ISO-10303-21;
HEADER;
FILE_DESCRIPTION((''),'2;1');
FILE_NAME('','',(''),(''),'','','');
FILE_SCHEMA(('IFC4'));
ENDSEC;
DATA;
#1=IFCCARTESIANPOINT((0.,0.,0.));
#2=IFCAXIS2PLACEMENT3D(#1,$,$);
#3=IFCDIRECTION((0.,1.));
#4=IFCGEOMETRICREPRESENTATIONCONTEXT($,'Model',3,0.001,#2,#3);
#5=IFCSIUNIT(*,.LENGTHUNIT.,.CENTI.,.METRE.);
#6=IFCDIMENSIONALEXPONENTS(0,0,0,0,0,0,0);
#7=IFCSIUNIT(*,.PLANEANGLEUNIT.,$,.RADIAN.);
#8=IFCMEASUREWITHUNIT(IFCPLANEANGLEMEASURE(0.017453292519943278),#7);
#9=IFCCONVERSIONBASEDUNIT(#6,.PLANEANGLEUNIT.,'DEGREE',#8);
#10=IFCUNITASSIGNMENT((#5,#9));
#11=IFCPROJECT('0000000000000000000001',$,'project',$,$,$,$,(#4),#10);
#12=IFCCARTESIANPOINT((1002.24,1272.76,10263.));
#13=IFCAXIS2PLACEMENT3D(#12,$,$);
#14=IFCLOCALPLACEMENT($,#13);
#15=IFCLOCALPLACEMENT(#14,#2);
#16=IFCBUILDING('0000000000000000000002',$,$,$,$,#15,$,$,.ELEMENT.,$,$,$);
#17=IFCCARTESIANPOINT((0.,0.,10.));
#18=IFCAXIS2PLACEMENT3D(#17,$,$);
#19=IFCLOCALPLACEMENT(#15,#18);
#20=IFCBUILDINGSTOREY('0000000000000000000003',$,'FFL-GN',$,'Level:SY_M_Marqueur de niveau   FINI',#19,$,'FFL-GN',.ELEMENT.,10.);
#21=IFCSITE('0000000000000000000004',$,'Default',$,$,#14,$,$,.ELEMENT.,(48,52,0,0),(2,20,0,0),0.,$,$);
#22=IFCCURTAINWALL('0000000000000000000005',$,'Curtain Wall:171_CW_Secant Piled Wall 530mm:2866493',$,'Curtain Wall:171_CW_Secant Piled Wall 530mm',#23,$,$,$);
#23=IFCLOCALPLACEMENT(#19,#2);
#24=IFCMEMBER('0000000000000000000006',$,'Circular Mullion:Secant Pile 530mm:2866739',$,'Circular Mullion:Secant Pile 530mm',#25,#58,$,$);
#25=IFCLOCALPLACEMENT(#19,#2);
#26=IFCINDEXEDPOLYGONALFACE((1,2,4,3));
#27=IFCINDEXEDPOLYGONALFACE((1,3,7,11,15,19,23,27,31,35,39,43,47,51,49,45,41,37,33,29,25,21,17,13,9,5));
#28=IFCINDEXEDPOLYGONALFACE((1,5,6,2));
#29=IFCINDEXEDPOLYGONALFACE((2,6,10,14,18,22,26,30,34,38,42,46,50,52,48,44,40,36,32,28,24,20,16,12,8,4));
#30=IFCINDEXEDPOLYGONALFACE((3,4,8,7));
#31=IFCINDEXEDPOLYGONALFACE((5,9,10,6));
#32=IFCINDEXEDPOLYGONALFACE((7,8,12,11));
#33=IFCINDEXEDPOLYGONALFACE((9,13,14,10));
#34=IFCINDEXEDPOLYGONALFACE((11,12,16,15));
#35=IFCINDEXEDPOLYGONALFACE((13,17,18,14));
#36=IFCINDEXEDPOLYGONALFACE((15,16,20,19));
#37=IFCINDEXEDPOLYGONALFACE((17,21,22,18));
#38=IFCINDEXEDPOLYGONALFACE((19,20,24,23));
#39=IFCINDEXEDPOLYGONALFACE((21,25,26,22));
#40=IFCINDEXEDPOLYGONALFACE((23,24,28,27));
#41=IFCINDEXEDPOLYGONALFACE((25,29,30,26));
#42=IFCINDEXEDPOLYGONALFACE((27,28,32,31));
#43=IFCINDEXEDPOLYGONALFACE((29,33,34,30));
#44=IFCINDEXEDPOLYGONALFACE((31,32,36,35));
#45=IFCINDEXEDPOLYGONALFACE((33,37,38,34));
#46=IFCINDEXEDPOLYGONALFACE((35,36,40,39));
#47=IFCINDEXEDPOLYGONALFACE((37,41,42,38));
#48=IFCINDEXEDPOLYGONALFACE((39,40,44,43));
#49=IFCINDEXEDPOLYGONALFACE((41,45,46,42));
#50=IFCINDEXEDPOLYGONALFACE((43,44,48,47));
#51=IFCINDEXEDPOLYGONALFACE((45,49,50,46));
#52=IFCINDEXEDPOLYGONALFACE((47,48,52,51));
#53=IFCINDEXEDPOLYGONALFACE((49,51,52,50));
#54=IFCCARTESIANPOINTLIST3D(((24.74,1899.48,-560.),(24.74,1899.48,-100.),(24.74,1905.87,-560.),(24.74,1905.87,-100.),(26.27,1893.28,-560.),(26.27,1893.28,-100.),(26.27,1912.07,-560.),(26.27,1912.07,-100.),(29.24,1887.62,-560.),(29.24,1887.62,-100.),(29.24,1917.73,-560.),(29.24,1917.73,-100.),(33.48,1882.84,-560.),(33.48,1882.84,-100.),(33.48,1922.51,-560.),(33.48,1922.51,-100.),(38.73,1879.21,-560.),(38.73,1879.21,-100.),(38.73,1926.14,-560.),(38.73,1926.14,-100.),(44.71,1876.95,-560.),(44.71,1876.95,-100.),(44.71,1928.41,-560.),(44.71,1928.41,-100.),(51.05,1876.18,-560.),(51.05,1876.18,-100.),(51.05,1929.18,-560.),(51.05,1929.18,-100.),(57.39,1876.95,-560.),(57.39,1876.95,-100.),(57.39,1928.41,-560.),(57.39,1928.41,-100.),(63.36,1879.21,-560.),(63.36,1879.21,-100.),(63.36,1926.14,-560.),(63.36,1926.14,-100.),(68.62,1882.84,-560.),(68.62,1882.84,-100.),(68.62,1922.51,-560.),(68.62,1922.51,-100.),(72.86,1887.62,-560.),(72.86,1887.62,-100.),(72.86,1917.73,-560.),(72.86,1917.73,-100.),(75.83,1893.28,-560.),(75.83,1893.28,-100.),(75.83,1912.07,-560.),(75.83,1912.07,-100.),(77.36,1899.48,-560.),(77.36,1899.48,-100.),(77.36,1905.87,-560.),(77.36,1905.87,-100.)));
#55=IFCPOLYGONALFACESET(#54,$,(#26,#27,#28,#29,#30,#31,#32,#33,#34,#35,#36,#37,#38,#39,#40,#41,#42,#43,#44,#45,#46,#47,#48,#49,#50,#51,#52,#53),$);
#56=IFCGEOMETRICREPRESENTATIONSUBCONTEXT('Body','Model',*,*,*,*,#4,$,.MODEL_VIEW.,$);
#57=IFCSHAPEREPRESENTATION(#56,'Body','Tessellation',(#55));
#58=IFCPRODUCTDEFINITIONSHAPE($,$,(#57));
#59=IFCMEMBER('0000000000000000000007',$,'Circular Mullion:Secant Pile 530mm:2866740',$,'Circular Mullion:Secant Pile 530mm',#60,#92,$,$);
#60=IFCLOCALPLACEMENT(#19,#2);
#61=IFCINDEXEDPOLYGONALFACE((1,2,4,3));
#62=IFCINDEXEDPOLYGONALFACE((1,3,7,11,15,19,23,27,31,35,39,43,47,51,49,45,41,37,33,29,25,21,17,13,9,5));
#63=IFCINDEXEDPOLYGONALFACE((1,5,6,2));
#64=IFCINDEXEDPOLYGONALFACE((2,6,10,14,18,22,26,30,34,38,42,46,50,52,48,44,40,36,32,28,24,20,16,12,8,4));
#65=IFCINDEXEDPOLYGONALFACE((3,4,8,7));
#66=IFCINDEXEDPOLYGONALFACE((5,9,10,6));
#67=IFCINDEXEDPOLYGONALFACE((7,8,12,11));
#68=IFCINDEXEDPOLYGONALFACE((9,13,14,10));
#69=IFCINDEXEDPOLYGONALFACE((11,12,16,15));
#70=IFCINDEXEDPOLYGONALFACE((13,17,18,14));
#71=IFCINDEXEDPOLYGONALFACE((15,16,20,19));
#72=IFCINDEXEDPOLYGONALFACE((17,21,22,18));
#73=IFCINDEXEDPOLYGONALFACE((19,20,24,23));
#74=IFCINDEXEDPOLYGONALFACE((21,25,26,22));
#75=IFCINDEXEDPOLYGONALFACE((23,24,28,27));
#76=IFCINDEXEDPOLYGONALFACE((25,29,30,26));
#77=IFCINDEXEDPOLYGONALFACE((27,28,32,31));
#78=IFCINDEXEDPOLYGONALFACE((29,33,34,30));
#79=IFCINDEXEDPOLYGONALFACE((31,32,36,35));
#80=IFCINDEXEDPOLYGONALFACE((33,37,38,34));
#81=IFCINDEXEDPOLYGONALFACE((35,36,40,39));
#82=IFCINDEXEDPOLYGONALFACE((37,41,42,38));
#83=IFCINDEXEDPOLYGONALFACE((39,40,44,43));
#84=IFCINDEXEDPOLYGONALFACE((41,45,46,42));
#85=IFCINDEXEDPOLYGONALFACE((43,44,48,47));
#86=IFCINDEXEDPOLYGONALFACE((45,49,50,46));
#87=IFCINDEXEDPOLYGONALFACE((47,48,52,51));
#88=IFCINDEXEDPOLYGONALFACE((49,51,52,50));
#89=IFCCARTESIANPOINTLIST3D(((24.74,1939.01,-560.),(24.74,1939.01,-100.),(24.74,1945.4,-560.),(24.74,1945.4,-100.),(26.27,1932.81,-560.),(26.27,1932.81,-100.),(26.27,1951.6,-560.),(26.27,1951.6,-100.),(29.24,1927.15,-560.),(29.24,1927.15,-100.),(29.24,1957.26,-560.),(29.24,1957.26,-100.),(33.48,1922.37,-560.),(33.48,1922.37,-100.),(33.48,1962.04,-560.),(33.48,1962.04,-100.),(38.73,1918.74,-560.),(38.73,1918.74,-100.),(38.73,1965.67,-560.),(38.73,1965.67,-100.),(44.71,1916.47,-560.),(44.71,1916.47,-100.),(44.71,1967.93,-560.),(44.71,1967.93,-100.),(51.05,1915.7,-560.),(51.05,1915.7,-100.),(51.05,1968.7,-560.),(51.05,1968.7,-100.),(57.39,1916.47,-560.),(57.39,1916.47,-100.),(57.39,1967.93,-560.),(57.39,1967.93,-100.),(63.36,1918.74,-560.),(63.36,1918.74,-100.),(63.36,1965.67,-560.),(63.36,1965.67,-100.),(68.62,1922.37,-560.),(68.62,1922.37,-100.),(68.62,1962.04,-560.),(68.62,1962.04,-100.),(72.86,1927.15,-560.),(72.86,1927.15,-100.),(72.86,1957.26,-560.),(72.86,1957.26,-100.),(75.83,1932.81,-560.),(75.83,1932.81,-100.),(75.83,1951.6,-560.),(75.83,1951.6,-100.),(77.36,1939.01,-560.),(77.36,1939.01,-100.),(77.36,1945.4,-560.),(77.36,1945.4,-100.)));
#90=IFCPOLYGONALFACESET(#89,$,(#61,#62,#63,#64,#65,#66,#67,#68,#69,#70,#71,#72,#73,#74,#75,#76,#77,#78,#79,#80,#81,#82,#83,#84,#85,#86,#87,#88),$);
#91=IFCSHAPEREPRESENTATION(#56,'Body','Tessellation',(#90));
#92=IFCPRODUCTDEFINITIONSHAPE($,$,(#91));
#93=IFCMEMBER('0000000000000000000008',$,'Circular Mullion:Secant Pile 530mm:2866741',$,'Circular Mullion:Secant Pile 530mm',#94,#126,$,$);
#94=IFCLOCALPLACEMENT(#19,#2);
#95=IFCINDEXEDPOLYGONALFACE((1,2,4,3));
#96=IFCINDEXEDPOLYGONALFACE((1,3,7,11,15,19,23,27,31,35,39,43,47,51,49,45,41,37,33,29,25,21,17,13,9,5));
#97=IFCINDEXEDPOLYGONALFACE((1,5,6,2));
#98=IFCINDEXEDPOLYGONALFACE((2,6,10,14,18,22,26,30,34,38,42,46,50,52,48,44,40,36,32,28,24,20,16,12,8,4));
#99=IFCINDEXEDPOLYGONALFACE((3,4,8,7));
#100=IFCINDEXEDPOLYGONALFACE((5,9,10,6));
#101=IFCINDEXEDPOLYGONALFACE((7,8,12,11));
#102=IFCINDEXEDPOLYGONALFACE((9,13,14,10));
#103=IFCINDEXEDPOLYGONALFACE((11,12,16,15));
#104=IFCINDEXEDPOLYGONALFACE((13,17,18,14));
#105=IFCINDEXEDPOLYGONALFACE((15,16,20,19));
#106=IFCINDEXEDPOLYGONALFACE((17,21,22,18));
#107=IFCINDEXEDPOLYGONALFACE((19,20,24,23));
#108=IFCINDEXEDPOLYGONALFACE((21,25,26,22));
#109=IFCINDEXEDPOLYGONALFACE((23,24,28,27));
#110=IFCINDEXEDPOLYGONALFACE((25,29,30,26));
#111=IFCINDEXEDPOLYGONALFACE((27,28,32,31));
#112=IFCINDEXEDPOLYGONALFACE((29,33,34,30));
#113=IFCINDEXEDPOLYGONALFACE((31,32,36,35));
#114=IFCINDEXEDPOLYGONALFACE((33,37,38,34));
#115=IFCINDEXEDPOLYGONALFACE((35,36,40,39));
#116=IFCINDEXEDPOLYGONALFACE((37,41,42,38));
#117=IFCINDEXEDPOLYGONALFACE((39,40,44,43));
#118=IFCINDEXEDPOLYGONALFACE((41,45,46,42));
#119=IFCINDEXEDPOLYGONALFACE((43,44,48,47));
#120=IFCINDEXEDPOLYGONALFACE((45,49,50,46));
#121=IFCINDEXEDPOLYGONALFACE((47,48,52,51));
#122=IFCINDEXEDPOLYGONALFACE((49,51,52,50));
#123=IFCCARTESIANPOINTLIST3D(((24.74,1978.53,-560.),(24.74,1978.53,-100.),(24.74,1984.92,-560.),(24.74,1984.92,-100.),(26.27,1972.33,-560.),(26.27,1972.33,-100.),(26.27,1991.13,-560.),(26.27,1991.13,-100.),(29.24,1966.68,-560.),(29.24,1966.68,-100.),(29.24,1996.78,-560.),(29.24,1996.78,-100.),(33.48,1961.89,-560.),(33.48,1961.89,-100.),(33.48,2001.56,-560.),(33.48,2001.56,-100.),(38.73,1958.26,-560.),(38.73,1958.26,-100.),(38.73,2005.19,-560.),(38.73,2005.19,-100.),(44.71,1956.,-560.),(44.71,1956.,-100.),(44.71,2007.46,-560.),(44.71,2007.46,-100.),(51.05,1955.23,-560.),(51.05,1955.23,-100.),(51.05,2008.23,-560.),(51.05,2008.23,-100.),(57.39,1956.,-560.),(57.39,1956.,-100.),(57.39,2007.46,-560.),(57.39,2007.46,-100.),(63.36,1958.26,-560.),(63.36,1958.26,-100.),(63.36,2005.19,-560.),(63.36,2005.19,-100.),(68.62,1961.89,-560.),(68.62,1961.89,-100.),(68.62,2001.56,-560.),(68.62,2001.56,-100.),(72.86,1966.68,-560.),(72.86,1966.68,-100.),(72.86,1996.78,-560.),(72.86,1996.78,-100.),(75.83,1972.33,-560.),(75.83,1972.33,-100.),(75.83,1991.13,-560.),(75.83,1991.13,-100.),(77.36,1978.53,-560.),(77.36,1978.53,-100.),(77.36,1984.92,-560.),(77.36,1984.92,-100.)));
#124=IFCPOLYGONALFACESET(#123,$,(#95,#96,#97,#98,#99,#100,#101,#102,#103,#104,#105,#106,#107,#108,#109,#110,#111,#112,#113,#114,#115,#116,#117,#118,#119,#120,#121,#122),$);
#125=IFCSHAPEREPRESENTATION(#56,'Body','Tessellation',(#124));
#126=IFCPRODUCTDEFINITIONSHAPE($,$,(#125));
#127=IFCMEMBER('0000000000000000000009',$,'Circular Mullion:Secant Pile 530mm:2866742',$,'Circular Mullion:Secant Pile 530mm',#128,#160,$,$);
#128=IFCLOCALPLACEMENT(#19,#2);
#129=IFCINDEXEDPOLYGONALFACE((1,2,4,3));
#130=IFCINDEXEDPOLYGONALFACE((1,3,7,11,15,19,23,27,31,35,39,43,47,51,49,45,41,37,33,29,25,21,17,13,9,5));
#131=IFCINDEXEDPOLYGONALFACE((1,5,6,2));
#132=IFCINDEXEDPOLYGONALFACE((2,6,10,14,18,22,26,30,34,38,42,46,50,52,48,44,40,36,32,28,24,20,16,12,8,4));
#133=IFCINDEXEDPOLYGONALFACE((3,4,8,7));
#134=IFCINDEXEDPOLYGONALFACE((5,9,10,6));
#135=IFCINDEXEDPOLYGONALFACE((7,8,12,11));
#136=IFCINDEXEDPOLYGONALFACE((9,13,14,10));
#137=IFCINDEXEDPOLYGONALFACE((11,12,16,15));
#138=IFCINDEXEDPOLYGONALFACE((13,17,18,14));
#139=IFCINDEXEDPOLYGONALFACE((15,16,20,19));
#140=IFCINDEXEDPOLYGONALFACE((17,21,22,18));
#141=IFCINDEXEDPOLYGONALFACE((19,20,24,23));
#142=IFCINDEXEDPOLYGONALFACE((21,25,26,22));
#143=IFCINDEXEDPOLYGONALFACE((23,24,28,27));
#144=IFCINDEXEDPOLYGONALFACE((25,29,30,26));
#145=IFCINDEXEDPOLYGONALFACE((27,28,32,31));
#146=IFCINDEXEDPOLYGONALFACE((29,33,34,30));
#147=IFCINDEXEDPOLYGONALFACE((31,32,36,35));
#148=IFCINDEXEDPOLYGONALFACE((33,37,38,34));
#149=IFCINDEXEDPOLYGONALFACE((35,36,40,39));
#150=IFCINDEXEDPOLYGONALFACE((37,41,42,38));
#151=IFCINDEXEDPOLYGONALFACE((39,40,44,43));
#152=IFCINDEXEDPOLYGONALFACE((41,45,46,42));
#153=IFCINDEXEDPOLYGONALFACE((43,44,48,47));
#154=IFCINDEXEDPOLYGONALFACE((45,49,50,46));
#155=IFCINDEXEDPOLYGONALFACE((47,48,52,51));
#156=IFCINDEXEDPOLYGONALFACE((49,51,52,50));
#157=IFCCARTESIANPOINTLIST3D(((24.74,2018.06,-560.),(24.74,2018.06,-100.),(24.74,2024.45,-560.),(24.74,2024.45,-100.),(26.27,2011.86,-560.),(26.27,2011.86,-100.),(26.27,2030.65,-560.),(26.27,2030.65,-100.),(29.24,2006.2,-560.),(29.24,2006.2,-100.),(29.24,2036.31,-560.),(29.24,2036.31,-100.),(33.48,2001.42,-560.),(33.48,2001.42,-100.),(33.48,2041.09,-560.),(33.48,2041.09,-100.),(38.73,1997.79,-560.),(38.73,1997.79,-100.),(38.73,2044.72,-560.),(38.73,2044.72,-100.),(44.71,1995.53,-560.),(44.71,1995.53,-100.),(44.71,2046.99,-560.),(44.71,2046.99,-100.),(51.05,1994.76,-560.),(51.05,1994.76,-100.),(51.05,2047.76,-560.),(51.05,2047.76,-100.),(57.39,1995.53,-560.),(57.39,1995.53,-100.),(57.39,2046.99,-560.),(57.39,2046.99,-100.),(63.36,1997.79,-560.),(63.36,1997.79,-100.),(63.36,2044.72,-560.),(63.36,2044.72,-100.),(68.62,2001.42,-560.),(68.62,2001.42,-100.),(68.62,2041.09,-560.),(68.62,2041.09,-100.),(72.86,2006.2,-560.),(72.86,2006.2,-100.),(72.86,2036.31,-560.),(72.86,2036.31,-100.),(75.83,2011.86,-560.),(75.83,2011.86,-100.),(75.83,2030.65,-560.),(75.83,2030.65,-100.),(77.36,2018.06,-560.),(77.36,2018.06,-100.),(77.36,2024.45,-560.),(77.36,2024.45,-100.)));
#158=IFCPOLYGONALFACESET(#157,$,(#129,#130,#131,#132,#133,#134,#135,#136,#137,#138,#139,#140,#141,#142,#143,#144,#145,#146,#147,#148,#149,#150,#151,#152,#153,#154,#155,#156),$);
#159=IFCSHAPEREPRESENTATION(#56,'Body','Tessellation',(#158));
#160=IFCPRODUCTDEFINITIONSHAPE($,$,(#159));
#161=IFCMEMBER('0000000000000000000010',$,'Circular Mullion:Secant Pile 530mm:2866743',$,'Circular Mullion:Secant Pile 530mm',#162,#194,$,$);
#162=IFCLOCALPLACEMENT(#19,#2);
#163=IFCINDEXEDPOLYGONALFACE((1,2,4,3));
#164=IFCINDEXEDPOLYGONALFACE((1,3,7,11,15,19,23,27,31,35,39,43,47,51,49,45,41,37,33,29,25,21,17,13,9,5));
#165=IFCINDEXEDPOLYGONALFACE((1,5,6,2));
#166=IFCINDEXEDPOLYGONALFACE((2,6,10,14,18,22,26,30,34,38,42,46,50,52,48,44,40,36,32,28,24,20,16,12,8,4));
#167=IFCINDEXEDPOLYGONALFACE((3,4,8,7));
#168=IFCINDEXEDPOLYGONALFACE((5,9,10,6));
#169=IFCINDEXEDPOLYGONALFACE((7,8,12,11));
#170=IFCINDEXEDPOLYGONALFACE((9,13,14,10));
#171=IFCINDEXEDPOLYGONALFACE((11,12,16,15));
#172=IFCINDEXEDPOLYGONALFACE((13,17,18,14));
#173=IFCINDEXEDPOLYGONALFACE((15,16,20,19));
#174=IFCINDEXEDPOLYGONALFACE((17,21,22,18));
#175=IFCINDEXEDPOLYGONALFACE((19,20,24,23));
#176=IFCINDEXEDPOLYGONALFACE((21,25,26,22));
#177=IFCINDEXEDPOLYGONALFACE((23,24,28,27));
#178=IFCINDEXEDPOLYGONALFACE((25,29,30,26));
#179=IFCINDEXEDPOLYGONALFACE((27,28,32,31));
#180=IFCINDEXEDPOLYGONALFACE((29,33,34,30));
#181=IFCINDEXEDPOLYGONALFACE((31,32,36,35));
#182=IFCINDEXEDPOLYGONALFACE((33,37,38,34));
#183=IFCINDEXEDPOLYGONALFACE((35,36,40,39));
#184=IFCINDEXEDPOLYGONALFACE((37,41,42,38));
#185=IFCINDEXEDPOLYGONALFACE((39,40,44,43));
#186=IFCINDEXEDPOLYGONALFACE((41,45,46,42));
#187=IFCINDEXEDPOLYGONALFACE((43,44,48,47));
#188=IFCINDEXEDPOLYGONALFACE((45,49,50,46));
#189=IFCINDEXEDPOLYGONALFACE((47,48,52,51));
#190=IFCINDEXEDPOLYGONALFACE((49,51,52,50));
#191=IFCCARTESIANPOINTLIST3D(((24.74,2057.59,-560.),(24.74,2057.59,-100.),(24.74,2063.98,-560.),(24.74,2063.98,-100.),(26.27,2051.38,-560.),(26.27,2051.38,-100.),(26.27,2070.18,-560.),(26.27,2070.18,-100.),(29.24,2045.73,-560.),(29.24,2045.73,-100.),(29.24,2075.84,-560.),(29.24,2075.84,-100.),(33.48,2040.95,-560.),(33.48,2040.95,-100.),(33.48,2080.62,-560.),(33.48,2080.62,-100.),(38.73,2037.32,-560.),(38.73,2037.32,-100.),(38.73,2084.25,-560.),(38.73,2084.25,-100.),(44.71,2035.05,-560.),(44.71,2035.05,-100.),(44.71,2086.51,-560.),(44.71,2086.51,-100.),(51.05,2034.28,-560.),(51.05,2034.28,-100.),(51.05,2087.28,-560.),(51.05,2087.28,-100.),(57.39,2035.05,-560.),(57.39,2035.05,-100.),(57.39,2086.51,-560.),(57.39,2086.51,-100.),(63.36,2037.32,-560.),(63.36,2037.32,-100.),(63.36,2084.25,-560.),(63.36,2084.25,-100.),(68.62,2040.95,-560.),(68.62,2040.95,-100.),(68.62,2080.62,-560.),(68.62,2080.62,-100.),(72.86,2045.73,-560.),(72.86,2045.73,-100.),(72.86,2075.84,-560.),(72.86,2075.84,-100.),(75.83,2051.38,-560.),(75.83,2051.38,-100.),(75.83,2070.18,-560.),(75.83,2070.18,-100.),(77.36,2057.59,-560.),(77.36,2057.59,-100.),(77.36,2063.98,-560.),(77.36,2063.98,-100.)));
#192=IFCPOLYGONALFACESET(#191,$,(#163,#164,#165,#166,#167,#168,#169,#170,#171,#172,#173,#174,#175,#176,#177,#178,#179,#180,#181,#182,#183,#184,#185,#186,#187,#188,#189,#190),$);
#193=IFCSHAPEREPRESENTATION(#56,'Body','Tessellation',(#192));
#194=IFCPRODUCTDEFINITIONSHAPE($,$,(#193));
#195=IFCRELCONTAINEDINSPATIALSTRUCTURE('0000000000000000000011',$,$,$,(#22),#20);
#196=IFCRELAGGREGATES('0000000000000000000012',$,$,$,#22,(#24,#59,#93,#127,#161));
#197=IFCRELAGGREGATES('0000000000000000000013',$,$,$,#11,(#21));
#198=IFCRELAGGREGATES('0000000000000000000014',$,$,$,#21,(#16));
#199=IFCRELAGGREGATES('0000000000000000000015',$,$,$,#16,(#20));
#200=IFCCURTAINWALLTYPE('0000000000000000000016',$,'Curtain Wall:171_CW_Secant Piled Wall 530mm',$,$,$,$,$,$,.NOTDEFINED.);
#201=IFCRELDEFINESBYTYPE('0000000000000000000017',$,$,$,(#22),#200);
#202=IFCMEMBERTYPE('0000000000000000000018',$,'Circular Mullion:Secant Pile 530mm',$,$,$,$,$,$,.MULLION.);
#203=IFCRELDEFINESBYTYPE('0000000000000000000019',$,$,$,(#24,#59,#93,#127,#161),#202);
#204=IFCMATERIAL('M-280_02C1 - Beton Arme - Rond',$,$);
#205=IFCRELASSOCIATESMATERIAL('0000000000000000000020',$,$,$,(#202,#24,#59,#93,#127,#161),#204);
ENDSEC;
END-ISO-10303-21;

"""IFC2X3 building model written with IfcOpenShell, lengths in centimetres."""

from ifc_helpers import new_model, entity, si_unit, converted_unit, direction, frame, frame_2d, origin, place, context, subcontext, project, spatial, circle, extrude, source, transform, mapped, material, type_object, type_shapes, element, aggregate, save


model = new_model("IFC2X3")

# Units and contexts
model_context = context("Model", 3, precision=0.001, world=origin(), true_north=direction((0.0, 1.0)))
body_context = subcontext(model_context, "Body", "Model", "MODEL_VIEW")
ifc_project = project(units=[si_unit("LENGTHUNIT", "METRE", prefix="CENTI"), converted_unit("PLANEANGLEUNIT", "DEGREE", entity("IfcPlaneAngleMeasure", 0.017453292519943278), si_unit("PLANEANGLEUNIT", "RADIAN"), dimensions=[0, 0, 0, 0, 0, 0, 0])], contexts=[model_context])

# Site, building, storey
site_placement = place(None, frame((1002.24, 1272.76, 10263.0)))
site = spatial("IfcSite", under=ifc_project, at=site_placement, Name="Default", CompositionType="ELEMENT", RefLatitude=(48, 52, 0, 0), RefLongitude=(2, 20, 0, 0), RefElevation=0.0)
building_placement = place(site_placement, origin())
building = spatial("IfcBuilding", under=site, at=building_placement, CompositionType="ELEMENT")
storey_placement = place(building_placement, frame((0.0, 0.0, 10.0)))
storey = spatial("IfcBuildingStorey", under=building, at=storey_placement, Name="FFL-GN", ObjectType="Level:SY_M_Marqueur de niveau   FINI", LongName="FFL-GN", CompositionType="ELEMENT", Elevation=10.0)

# Curtain wall, members
curtain_wall_type = type_object("IfcCurtainWallType", Name="Curtain Wall:171_CW_Secant Piled Wall 530mm", PredefinedType="NOTDEFINED")
curtain_wall_placement = place(storey_placement, frame((0.0, 0.0, -10.0)))
curtain_wall = element("IfcCurtainWall", 1, at=curtain_wall_placement, inside=storey, type_object=curtain_wall_type, Name="Curtain Wall:171_CW_Secant Piled Wall 530mm:2866493", ObjectType="Curtain Wall:171_CW_Secant Piled Wall 530mm")
ifc_material_1 = material(Name="M-280_02C1 - Beton Arme - Rond")
member_type = type_object("IfcMemberType", Name="Circular Mullion:Secant Pile 530mm", PredefinedType="MULLION", material=ifc_material_1)
shared_shape = source(origin(), body_context, "Body", "SweptSolid", [
    extrude(circle(Radius=26.5, at=frame_2d((0.0, 0.0), x_axis=(1.0, 0.0))), frame((0.0, 0.0, -460.0)), (0.0, 0.0, 1.0), 460.0),
])
type_shapes(member_type, [shared_shape])
member_1_placement = place(curtain_wall_placement, frame((51.05, 1902.68, -550.0), z_axis=(0.0, 0.0, -1.0), x_axis=(0.0, 1.0, 0.0)))
member_1 = element("IfcMember", 2, at=member_1_placement, type_object=member_type, material=ifc_material_1, Name="Circular Mullion:Secant Pile 530mm:2866739", ObjectType="Circular Mullion:Secant Pile 530mm", context=body_context, shape_type="MappedRepresentation", body=[
    mapped(shared_shape, transform((0.0, 0.0, 0.0), scale=1.0)),
])
member_2_placement = place(curtain_wall_placement, frame((51.05, 1942.2, -550.0), z_axis=(0.0, 0.0, -1.0), x_axis=(0.0, 1.0, 0.0)))
member_2 = element("IfcMember", 3, at=member_2_placement, type_object=member_type, material=ifc_material_1, Name="Circular Mullion:Secant Pile 530mm:2866740", ObjectType="Circular Mullion:Secant Pile 530mm", context=body_context, shape_type="MappedRepresentation", body=[
    mapped(shared_shape, transform((0.0, 0.0, 0.0), scale=1.0)),
])
member_3_placement = place(curtain_wall_placement, frame((51.05, 1981.73, -550.0), z_axis=(0.0, 0.0, -1.0), x_axis=(0.0, 1.0, 0.0)))
member_3 = element("IfcMember", 4, at=member_3_placement, type_object=member_type, material=ifc_material_1, Name="Circular Mullion:Secant Pile 530mm:2866741", ObjectType="Circular Mullion:Secant Pile 530mm", context=body_context, shape_type="MappedRepresentation", body=[
    mapped(shared_shape, transform((0.0, 0.0, 0.0), scale=1.0)),
])
member_4_placement = place(curtain_wall_placement, frame((51.05, 2021.26, -550.0), z_axis=(0.0, 0.0, -1.0), x_axis=(0.0, 1.0, 0.0)))
member_4 = element("IfcMember", 5, at=member_4_placement, type_object=member_type, material=ifc_material_1, Name="Circular Mullion:Secant Pile 530mm:2866742", ObjectType="Circular Mullion:Secant Pile 530mm", context=body_context, shape_type="MappedRepresentation", body=[
    mapped(shared_shape, transform((0.0, 0.0, 0.0), scale=1.0)),
])
member_5_placement = place(curtain_wall_placement, frame((51.05, 2060.78, -550.0), z_axis=(0.0, 0.0, -1.0), x_axis=(0.0, 1.0, 0.0)))
member_5 = element("IfcMember", 6, at=member_5_placement, type_object=member_type, material=ifc_material_1, Name="Circular Mullion:Secant Pile 530mm:2866743", ObjectType="Circular Mullion:Secant Pile 530mm", context=body_context, shape_type="MappedRepresentation", body=[
    mapped(shared_shape, transform((0.0, 0.0, 0.0), scale=1.0)),
])
aggregate(curtain_wall, [member_1, member_2, member_3, member_4, member_5])

save(model, "model.ifc")
